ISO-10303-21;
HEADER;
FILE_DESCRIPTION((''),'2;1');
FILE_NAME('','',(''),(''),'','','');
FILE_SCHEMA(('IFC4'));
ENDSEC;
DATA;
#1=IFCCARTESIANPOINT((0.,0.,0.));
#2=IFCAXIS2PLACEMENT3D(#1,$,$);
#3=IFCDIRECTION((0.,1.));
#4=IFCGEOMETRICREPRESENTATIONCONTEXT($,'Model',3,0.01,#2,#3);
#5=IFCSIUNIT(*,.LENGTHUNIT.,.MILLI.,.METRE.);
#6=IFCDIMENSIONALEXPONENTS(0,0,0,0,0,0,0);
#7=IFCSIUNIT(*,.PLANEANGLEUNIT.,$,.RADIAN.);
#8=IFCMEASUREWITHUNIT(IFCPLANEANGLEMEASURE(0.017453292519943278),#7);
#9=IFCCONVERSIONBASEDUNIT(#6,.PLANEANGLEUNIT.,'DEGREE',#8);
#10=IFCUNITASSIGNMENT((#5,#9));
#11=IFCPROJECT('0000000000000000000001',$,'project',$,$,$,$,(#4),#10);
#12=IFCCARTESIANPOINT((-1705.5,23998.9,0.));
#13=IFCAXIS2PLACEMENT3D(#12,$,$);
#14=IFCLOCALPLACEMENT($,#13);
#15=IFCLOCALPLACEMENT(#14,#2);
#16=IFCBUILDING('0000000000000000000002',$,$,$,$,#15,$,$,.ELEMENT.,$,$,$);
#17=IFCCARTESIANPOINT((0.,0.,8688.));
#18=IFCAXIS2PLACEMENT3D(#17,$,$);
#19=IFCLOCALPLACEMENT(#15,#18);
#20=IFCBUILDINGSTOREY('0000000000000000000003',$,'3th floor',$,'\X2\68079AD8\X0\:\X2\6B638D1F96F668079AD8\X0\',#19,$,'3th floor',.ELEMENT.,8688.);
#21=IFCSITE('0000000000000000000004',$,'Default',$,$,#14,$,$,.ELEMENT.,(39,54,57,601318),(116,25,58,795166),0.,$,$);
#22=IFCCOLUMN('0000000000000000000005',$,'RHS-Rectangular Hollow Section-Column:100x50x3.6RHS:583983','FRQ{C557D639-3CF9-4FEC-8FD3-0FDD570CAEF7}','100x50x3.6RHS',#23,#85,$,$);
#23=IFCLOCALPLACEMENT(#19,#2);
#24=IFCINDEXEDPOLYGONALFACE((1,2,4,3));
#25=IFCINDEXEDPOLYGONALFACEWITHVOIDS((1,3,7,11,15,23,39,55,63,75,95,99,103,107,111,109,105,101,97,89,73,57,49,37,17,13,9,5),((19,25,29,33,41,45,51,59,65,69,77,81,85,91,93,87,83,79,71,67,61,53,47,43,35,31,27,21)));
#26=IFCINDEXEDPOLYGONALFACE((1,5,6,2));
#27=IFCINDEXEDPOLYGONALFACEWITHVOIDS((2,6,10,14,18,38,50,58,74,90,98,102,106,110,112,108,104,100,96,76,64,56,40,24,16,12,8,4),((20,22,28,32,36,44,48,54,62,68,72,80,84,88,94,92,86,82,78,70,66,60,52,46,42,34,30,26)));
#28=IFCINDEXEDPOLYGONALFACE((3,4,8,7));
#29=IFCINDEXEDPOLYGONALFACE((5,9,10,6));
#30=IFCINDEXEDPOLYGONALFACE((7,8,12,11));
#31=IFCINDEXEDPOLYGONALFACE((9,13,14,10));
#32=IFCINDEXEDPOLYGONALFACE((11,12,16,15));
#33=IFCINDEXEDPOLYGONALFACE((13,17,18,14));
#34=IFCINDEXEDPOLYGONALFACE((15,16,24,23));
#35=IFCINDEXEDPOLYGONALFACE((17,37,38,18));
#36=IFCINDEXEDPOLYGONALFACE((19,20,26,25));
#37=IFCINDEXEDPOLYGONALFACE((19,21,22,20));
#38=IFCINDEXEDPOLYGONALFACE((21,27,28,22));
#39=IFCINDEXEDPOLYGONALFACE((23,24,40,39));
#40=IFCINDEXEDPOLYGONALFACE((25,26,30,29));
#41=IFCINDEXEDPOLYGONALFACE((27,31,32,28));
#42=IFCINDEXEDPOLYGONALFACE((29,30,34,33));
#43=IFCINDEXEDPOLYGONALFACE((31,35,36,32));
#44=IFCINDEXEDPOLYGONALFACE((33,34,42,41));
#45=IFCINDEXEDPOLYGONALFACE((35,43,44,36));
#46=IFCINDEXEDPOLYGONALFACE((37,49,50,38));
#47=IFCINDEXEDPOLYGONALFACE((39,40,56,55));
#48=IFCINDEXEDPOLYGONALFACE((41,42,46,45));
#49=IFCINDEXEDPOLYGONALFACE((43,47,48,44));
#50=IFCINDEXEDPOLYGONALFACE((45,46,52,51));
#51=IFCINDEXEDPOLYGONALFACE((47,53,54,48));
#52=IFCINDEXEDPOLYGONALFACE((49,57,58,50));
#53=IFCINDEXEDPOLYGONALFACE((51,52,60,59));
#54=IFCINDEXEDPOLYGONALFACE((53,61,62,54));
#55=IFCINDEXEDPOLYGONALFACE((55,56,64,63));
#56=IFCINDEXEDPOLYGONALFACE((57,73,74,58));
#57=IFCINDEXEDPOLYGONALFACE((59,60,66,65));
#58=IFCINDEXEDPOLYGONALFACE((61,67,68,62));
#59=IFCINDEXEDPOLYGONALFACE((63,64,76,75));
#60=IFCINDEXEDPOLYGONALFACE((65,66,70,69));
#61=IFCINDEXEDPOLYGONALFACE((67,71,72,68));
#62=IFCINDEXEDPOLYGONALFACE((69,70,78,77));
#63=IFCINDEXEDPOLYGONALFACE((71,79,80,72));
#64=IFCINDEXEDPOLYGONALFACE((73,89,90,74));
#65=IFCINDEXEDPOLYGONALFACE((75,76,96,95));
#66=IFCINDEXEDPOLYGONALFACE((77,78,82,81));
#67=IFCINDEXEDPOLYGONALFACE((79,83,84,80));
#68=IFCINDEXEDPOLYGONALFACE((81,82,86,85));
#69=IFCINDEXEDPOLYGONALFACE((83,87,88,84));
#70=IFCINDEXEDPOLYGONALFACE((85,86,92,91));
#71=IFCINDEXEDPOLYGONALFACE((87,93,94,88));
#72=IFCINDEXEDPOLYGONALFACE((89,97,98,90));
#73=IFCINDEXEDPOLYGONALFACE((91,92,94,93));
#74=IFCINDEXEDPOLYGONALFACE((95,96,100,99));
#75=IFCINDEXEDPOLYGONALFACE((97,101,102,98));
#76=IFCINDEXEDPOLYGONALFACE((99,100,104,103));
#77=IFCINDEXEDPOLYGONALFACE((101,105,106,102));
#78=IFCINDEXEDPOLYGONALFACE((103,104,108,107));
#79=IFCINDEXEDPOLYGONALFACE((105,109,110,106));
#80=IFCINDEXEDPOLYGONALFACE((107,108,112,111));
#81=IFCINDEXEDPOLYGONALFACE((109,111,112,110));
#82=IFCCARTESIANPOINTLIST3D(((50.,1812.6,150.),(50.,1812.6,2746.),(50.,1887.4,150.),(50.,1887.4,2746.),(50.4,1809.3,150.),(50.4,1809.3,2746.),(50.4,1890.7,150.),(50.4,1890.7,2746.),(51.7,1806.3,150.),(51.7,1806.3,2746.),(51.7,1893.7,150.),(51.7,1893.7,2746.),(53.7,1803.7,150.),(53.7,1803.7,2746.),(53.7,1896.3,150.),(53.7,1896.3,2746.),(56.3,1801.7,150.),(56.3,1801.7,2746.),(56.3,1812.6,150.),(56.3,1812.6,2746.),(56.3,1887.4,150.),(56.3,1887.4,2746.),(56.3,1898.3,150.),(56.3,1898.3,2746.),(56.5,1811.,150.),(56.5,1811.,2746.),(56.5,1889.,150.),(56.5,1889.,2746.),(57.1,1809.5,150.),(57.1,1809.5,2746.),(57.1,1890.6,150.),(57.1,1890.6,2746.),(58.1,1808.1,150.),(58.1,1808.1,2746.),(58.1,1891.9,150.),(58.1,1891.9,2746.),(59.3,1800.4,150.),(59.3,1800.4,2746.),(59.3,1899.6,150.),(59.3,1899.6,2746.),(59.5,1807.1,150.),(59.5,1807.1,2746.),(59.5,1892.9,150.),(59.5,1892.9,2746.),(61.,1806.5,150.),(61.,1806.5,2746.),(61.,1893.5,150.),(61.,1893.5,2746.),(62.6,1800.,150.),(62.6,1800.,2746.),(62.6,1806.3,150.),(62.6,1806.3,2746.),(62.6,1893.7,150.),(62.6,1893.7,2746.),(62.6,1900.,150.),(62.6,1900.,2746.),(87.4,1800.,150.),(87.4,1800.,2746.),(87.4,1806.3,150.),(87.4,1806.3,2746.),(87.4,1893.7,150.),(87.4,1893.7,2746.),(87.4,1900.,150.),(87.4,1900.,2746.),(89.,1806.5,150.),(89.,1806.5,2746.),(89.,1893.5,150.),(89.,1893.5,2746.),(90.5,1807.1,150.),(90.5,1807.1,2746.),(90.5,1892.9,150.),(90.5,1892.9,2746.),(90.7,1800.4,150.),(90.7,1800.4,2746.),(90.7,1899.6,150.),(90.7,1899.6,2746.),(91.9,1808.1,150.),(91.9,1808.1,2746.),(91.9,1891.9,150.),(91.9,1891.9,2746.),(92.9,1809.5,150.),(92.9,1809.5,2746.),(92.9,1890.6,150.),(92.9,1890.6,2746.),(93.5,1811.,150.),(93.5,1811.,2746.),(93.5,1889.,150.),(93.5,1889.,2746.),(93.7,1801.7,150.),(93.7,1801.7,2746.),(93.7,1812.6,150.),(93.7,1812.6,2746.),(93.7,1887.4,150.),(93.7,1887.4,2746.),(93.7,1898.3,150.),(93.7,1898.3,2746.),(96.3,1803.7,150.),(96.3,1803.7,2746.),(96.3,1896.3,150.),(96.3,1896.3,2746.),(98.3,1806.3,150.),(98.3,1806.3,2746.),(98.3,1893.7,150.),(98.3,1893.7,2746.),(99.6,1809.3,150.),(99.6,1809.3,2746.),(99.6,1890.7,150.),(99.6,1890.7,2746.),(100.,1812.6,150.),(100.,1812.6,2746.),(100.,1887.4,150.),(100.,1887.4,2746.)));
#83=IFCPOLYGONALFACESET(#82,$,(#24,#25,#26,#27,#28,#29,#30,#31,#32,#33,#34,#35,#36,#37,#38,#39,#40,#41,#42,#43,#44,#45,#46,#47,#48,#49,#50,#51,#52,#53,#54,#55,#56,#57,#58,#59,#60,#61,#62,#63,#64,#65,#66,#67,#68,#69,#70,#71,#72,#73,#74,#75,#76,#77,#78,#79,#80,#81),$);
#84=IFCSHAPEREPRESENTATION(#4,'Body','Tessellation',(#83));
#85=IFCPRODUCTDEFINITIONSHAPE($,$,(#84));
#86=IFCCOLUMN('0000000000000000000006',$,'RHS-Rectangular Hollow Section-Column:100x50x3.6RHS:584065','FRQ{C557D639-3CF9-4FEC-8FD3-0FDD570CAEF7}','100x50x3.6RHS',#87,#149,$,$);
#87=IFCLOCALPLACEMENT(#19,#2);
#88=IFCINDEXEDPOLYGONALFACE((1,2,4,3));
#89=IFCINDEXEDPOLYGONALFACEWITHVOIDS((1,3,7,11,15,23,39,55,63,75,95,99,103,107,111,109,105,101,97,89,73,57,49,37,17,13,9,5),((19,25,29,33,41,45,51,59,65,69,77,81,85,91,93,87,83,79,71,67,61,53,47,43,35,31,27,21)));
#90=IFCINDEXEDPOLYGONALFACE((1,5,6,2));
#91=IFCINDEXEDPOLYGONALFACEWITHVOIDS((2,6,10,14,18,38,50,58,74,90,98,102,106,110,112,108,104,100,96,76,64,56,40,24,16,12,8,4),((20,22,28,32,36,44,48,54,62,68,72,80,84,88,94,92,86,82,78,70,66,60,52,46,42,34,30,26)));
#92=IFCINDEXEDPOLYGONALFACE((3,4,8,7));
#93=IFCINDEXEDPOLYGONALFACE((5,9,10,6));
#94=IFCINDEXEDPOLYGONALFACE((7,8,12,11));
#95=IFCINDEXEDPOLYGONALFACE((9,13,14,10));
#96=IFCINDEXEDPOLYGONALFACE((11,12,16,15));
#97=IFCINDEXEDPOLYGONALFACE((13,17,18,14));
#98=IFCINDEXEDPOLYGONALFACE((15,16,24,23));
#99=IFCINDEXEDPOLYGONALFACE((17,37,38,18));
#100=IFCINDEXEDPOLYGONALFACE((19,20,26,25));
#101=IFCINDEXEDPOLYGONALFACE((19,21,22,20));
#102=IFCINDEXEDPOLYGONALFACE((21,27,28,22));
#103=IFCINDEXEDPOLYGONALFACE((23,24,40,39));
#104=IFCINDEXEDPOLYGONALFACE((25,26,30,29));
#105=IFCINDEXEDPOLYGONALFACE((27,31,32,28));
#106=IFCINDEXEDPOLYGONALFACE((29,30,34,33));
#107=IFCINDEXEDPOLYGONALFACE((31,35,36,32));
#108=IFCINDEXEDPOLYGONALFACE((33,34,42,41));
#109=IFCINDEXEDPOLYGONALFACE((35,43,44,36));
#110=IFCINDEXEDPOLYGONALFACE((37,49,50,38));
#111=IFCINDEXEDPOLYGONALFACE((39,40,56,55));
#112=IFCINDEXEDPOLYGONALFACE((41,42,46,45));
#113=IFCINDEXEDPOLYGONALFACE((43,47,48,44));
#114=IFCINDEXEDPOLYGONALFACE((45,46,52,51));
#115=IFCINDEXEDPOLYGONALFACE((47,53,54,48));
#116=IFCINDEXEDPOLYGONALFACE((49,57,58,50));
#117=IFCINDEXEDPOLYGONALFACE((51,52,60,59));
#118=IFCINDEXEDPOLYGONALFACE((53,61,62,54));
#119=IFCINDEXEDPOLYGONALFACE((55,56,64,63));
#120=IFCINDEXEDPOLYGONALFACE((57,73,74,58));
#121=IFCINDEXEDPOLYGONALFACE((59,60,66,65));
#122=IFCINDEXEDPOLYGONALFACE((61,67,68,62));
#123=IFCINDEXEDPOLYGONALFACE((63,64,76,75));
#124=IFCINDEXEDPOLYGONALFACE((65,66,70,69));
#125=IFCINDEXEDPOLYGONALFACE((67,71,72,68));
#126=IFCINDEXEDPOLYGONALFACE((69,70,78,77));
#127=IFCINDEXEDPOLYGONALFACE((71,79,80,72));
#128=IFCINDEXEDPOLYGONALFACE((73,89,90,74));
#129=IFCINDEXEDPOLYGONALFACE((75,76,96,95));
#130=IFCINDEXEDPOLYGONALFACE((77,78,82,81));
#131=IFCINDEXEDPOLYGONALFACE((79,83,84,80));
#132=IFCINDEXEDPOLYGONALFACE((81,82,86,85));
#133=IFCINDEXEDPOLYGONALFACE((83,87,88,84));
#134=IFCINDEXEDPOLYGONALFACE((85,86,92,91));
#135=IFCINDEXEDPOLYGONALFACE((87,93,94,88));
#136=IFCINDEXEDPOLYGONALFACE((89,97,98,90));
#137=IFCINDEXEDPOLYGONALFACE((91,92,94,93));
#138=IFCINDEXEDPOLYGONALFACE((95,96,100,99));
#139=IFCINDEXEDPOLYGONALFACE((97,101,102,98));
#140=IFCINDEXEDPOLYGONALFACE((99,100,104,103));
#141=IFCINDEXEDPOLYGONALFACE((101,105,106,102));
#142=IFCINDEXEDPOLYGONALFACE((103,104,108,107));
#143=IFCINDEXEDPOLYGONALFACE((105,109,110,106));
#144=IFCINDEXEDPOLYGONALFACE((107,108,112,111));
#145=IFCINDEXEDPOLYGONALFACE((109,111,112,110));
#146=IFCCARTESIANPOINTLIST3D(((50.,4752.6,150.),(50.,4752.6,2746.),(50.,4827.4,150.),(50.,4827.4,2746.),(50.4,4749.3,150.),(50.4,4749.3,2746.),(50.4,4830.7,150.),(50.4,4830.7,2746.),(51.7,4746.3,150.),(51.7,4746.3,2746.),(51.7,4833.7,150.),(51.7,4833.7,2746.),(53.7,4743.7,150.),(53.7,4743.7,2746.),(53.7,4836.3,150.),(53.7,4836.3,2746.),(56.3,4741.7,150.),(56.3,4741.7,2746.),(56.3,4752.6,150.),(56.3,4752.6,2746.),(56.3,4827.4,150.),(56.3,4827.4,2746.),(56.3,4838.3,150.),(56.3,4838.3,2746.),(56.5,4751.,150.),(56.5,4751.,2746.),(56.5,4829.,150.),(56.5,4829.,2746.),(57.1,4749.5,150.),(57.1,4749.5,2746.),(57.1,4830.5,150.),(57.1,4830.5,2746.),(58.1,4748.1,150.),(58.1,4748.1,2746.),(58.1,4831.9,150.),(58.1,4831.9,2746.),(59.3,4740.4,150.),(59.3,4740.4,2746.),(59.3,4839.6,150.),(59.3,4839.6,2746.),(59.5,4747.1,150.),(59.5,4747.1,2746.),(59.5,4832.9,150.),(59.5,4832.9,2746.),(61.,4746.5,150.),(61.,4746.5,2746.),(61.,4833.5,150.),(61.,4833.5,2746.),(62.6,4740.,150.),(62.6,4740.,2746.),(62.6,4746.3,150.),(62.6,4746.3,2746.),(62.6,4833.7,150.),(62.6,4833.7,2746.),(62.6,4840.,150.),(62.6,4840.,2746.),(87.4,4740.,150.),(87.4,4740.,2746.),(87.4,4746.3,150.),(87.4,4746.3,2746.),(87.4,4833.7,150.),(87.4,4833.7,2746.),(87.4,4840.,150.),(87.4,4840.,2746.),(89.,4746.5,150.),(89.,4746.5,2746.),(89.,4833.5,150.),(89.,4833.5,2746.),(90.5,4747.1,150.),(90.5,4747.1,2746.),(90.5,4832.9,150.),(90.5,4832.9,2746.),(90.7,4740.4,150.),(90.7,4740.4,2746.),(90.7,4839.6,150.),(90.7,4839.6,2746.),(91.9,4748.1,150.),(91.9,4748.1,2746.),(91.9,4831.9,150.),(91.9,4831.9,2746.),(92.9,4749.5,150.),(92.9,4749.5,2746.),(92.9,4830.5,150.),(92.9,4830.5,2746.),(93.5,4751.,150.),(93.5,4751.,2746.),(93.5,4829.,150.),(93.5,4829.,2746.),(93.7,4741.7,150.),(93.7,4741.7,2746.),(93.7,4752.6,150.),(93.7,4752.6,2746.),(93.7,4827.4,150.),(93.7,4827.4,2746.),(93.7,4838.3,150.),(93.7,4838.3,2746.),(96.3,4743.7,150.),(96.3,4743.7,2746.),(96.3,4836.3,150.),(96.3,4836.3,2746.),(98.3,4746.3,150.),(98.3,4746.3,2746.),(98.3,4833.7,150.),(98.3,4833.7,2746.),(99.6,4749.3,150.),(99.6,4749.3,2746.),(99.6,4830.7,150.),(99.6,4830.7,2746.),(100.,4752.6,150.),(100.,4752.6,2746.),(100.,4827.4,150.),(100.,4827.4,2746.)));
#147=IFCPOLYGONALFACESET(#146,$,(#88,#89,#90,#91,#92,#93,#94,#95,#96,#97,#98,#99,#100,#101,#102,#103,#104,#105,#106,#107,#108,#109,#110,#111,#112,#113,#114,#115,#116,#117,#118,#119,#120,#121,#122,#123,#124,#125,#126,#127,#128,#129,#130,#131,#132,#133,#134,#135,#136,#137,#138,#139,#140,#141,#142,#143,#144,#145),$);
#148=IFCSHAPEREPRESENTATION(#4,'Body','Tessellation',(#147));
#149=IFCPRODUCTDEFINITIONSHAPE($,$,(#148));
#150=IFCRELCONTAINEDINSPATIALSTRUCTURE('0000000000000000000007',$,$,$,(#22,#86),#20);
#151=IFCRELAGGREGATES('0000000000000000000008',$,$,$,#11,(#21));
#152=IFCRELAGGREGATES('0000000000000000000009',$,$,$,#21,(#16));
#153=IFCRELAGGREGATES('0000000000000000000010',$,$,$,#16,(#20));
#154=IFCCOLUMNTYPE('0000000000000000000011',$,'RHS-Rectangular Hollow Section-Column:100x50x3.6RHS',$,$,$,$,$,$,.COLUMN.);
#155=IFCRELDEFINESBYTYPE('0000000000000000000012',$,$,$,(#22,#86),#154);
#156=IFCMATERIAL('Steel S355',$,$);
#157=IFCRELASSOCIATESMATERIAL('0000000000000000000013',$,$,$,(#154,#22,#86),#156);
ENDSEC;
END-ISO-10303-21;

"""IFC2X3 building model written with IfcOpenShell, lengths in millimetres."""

from ifc_helpers import new_model, entity, si_unit, converted_unit, direction, frame, origin, origin_2d, place, context, project, spatial, hollow_rectangle, extrude, clip, halfspace, material, type_object, element, save


model = new_model("IFC2X3")

# Units and contexts
model_context = context("Model", 3, precision=0.01, world=origin(), true_north=direction((0.0, 1.0)))
ifc_project = project(units=[si_unit("LENGTHUNIT", "METRE", prefix="MILLI"), converted_unit("PLANEANGLEUNIT", "DEGREE", entity("IfcPlaneAngleMeasure", 0.017453292519943278), si_unit("PLANEANGLEUNIT", "RADIAN"), dimensions=[0, 0, 0, 0, 0, 0, 0])], contexts=[model_context])

# Site, building, storey
site_placement = place(None, frame((-1705.5, 23998.9, 0.0)))
site = spatial("IfcSite", under=ifc_project, at=site_placement, Name="Default", CompositionType="ELEMENT", RefLatitude=(39, 54, 57, 601318), RefLongitude=(116, 25, 58, 795166), RefElevation=0.0)
building_placement = place(site_placement, origin())
building = spatial("IfcBuilding", under=site, at=building_placement, CompositionType="ELEMENT")
storey_placement = place(building_placement, frame((0.0, 0.0, 8688.0)))
storey = spatial("IfcBuildingStorey", under=building, at=storey_placement, Name="3th floor", ObjectType="标高:正负零标高", LongName="3th floor", CompositionType="ELEMENT", Elevation=8688.0)

# Columns
ifc_material = material(Name="Steel S355")
column_type_1 = type_object("IfcColumnType", Name="RHS-Rectangular Hollow Section-Column:100x50x3.6RHS", PredefinedType="COLUMN", material=ifc_material)
column_1_placement = place(storey_placement, frame((75.0, 1850.0, 2746.0), z_axis=(0.0, 0.0, 1.0), x_axis=(-1.0, 0.0, 0.0)))
element("IfcColumn", 1, at=column_1_placement, inside=storey, type_object=column_type_1, material=ifc_material, Name="RHS-Rectangular Hollow Section-Column:100x50x3.6RHS:583983", Description="FRQ{C557D639-3CF9-4FEC-8FD3-0FDD570CAEF7}", ObjectType="100x50x3.6RHS", context=model_context, shape_type="Clipping", body=[
    clip(extrude(hollow_rectangle(XDim=50.0, YDim=100.0, WallThickness=6.3, InnerFilletRadius=6.3, OuterFilletRadius=12.6, at=origin_2d()), origin(), (0.0, 0.0, -1.0), 2651.9), halfspace(frame((75.0, 1850.0, -2596.0), z_axis=(0.0, 0.0, 1.0), x_axis=(-1.0, 0.0, 0.0)), True)),
])
column_2_placement = place(storey_placement, frame((75.0, 4790.0, 2746.0), z_axis=(0.0, 0.0, 1.0), x_axis=(-1.0, 0.0, 0.0)))
element("IfcColumn", 2, at=column_2_placement, inside=storey, type_object=column_type_1, material=ifc_material, Name="RHS-Rectangular Hollow Section-Column:100x50x3.6RHS:584065", Description="FRQ{C557D639-3CF9-4FEC-8FD3-0FDD570CAEF7}", ObjectType="100x50x3.6RHS", context=model_context, shape_type="Clipping", body=[
    clip(extrude(hollow_rectangle(XDim=50.0, YDim=100.0, WallThickness=6.3, InnerFilletRadius=6.3, OuterFilletRadius=12.6, at=origin_2d()), origin(), (0.0, 0.0, -1.0), 2651.9), halfspace(frame((75.0, 4790.0, -2596.0), z_axis=(0.0, 0.0, 1.0), x_axis=(-1.0, 0.0, 0.0)), True)),
])

save(model, "model.ifc")
